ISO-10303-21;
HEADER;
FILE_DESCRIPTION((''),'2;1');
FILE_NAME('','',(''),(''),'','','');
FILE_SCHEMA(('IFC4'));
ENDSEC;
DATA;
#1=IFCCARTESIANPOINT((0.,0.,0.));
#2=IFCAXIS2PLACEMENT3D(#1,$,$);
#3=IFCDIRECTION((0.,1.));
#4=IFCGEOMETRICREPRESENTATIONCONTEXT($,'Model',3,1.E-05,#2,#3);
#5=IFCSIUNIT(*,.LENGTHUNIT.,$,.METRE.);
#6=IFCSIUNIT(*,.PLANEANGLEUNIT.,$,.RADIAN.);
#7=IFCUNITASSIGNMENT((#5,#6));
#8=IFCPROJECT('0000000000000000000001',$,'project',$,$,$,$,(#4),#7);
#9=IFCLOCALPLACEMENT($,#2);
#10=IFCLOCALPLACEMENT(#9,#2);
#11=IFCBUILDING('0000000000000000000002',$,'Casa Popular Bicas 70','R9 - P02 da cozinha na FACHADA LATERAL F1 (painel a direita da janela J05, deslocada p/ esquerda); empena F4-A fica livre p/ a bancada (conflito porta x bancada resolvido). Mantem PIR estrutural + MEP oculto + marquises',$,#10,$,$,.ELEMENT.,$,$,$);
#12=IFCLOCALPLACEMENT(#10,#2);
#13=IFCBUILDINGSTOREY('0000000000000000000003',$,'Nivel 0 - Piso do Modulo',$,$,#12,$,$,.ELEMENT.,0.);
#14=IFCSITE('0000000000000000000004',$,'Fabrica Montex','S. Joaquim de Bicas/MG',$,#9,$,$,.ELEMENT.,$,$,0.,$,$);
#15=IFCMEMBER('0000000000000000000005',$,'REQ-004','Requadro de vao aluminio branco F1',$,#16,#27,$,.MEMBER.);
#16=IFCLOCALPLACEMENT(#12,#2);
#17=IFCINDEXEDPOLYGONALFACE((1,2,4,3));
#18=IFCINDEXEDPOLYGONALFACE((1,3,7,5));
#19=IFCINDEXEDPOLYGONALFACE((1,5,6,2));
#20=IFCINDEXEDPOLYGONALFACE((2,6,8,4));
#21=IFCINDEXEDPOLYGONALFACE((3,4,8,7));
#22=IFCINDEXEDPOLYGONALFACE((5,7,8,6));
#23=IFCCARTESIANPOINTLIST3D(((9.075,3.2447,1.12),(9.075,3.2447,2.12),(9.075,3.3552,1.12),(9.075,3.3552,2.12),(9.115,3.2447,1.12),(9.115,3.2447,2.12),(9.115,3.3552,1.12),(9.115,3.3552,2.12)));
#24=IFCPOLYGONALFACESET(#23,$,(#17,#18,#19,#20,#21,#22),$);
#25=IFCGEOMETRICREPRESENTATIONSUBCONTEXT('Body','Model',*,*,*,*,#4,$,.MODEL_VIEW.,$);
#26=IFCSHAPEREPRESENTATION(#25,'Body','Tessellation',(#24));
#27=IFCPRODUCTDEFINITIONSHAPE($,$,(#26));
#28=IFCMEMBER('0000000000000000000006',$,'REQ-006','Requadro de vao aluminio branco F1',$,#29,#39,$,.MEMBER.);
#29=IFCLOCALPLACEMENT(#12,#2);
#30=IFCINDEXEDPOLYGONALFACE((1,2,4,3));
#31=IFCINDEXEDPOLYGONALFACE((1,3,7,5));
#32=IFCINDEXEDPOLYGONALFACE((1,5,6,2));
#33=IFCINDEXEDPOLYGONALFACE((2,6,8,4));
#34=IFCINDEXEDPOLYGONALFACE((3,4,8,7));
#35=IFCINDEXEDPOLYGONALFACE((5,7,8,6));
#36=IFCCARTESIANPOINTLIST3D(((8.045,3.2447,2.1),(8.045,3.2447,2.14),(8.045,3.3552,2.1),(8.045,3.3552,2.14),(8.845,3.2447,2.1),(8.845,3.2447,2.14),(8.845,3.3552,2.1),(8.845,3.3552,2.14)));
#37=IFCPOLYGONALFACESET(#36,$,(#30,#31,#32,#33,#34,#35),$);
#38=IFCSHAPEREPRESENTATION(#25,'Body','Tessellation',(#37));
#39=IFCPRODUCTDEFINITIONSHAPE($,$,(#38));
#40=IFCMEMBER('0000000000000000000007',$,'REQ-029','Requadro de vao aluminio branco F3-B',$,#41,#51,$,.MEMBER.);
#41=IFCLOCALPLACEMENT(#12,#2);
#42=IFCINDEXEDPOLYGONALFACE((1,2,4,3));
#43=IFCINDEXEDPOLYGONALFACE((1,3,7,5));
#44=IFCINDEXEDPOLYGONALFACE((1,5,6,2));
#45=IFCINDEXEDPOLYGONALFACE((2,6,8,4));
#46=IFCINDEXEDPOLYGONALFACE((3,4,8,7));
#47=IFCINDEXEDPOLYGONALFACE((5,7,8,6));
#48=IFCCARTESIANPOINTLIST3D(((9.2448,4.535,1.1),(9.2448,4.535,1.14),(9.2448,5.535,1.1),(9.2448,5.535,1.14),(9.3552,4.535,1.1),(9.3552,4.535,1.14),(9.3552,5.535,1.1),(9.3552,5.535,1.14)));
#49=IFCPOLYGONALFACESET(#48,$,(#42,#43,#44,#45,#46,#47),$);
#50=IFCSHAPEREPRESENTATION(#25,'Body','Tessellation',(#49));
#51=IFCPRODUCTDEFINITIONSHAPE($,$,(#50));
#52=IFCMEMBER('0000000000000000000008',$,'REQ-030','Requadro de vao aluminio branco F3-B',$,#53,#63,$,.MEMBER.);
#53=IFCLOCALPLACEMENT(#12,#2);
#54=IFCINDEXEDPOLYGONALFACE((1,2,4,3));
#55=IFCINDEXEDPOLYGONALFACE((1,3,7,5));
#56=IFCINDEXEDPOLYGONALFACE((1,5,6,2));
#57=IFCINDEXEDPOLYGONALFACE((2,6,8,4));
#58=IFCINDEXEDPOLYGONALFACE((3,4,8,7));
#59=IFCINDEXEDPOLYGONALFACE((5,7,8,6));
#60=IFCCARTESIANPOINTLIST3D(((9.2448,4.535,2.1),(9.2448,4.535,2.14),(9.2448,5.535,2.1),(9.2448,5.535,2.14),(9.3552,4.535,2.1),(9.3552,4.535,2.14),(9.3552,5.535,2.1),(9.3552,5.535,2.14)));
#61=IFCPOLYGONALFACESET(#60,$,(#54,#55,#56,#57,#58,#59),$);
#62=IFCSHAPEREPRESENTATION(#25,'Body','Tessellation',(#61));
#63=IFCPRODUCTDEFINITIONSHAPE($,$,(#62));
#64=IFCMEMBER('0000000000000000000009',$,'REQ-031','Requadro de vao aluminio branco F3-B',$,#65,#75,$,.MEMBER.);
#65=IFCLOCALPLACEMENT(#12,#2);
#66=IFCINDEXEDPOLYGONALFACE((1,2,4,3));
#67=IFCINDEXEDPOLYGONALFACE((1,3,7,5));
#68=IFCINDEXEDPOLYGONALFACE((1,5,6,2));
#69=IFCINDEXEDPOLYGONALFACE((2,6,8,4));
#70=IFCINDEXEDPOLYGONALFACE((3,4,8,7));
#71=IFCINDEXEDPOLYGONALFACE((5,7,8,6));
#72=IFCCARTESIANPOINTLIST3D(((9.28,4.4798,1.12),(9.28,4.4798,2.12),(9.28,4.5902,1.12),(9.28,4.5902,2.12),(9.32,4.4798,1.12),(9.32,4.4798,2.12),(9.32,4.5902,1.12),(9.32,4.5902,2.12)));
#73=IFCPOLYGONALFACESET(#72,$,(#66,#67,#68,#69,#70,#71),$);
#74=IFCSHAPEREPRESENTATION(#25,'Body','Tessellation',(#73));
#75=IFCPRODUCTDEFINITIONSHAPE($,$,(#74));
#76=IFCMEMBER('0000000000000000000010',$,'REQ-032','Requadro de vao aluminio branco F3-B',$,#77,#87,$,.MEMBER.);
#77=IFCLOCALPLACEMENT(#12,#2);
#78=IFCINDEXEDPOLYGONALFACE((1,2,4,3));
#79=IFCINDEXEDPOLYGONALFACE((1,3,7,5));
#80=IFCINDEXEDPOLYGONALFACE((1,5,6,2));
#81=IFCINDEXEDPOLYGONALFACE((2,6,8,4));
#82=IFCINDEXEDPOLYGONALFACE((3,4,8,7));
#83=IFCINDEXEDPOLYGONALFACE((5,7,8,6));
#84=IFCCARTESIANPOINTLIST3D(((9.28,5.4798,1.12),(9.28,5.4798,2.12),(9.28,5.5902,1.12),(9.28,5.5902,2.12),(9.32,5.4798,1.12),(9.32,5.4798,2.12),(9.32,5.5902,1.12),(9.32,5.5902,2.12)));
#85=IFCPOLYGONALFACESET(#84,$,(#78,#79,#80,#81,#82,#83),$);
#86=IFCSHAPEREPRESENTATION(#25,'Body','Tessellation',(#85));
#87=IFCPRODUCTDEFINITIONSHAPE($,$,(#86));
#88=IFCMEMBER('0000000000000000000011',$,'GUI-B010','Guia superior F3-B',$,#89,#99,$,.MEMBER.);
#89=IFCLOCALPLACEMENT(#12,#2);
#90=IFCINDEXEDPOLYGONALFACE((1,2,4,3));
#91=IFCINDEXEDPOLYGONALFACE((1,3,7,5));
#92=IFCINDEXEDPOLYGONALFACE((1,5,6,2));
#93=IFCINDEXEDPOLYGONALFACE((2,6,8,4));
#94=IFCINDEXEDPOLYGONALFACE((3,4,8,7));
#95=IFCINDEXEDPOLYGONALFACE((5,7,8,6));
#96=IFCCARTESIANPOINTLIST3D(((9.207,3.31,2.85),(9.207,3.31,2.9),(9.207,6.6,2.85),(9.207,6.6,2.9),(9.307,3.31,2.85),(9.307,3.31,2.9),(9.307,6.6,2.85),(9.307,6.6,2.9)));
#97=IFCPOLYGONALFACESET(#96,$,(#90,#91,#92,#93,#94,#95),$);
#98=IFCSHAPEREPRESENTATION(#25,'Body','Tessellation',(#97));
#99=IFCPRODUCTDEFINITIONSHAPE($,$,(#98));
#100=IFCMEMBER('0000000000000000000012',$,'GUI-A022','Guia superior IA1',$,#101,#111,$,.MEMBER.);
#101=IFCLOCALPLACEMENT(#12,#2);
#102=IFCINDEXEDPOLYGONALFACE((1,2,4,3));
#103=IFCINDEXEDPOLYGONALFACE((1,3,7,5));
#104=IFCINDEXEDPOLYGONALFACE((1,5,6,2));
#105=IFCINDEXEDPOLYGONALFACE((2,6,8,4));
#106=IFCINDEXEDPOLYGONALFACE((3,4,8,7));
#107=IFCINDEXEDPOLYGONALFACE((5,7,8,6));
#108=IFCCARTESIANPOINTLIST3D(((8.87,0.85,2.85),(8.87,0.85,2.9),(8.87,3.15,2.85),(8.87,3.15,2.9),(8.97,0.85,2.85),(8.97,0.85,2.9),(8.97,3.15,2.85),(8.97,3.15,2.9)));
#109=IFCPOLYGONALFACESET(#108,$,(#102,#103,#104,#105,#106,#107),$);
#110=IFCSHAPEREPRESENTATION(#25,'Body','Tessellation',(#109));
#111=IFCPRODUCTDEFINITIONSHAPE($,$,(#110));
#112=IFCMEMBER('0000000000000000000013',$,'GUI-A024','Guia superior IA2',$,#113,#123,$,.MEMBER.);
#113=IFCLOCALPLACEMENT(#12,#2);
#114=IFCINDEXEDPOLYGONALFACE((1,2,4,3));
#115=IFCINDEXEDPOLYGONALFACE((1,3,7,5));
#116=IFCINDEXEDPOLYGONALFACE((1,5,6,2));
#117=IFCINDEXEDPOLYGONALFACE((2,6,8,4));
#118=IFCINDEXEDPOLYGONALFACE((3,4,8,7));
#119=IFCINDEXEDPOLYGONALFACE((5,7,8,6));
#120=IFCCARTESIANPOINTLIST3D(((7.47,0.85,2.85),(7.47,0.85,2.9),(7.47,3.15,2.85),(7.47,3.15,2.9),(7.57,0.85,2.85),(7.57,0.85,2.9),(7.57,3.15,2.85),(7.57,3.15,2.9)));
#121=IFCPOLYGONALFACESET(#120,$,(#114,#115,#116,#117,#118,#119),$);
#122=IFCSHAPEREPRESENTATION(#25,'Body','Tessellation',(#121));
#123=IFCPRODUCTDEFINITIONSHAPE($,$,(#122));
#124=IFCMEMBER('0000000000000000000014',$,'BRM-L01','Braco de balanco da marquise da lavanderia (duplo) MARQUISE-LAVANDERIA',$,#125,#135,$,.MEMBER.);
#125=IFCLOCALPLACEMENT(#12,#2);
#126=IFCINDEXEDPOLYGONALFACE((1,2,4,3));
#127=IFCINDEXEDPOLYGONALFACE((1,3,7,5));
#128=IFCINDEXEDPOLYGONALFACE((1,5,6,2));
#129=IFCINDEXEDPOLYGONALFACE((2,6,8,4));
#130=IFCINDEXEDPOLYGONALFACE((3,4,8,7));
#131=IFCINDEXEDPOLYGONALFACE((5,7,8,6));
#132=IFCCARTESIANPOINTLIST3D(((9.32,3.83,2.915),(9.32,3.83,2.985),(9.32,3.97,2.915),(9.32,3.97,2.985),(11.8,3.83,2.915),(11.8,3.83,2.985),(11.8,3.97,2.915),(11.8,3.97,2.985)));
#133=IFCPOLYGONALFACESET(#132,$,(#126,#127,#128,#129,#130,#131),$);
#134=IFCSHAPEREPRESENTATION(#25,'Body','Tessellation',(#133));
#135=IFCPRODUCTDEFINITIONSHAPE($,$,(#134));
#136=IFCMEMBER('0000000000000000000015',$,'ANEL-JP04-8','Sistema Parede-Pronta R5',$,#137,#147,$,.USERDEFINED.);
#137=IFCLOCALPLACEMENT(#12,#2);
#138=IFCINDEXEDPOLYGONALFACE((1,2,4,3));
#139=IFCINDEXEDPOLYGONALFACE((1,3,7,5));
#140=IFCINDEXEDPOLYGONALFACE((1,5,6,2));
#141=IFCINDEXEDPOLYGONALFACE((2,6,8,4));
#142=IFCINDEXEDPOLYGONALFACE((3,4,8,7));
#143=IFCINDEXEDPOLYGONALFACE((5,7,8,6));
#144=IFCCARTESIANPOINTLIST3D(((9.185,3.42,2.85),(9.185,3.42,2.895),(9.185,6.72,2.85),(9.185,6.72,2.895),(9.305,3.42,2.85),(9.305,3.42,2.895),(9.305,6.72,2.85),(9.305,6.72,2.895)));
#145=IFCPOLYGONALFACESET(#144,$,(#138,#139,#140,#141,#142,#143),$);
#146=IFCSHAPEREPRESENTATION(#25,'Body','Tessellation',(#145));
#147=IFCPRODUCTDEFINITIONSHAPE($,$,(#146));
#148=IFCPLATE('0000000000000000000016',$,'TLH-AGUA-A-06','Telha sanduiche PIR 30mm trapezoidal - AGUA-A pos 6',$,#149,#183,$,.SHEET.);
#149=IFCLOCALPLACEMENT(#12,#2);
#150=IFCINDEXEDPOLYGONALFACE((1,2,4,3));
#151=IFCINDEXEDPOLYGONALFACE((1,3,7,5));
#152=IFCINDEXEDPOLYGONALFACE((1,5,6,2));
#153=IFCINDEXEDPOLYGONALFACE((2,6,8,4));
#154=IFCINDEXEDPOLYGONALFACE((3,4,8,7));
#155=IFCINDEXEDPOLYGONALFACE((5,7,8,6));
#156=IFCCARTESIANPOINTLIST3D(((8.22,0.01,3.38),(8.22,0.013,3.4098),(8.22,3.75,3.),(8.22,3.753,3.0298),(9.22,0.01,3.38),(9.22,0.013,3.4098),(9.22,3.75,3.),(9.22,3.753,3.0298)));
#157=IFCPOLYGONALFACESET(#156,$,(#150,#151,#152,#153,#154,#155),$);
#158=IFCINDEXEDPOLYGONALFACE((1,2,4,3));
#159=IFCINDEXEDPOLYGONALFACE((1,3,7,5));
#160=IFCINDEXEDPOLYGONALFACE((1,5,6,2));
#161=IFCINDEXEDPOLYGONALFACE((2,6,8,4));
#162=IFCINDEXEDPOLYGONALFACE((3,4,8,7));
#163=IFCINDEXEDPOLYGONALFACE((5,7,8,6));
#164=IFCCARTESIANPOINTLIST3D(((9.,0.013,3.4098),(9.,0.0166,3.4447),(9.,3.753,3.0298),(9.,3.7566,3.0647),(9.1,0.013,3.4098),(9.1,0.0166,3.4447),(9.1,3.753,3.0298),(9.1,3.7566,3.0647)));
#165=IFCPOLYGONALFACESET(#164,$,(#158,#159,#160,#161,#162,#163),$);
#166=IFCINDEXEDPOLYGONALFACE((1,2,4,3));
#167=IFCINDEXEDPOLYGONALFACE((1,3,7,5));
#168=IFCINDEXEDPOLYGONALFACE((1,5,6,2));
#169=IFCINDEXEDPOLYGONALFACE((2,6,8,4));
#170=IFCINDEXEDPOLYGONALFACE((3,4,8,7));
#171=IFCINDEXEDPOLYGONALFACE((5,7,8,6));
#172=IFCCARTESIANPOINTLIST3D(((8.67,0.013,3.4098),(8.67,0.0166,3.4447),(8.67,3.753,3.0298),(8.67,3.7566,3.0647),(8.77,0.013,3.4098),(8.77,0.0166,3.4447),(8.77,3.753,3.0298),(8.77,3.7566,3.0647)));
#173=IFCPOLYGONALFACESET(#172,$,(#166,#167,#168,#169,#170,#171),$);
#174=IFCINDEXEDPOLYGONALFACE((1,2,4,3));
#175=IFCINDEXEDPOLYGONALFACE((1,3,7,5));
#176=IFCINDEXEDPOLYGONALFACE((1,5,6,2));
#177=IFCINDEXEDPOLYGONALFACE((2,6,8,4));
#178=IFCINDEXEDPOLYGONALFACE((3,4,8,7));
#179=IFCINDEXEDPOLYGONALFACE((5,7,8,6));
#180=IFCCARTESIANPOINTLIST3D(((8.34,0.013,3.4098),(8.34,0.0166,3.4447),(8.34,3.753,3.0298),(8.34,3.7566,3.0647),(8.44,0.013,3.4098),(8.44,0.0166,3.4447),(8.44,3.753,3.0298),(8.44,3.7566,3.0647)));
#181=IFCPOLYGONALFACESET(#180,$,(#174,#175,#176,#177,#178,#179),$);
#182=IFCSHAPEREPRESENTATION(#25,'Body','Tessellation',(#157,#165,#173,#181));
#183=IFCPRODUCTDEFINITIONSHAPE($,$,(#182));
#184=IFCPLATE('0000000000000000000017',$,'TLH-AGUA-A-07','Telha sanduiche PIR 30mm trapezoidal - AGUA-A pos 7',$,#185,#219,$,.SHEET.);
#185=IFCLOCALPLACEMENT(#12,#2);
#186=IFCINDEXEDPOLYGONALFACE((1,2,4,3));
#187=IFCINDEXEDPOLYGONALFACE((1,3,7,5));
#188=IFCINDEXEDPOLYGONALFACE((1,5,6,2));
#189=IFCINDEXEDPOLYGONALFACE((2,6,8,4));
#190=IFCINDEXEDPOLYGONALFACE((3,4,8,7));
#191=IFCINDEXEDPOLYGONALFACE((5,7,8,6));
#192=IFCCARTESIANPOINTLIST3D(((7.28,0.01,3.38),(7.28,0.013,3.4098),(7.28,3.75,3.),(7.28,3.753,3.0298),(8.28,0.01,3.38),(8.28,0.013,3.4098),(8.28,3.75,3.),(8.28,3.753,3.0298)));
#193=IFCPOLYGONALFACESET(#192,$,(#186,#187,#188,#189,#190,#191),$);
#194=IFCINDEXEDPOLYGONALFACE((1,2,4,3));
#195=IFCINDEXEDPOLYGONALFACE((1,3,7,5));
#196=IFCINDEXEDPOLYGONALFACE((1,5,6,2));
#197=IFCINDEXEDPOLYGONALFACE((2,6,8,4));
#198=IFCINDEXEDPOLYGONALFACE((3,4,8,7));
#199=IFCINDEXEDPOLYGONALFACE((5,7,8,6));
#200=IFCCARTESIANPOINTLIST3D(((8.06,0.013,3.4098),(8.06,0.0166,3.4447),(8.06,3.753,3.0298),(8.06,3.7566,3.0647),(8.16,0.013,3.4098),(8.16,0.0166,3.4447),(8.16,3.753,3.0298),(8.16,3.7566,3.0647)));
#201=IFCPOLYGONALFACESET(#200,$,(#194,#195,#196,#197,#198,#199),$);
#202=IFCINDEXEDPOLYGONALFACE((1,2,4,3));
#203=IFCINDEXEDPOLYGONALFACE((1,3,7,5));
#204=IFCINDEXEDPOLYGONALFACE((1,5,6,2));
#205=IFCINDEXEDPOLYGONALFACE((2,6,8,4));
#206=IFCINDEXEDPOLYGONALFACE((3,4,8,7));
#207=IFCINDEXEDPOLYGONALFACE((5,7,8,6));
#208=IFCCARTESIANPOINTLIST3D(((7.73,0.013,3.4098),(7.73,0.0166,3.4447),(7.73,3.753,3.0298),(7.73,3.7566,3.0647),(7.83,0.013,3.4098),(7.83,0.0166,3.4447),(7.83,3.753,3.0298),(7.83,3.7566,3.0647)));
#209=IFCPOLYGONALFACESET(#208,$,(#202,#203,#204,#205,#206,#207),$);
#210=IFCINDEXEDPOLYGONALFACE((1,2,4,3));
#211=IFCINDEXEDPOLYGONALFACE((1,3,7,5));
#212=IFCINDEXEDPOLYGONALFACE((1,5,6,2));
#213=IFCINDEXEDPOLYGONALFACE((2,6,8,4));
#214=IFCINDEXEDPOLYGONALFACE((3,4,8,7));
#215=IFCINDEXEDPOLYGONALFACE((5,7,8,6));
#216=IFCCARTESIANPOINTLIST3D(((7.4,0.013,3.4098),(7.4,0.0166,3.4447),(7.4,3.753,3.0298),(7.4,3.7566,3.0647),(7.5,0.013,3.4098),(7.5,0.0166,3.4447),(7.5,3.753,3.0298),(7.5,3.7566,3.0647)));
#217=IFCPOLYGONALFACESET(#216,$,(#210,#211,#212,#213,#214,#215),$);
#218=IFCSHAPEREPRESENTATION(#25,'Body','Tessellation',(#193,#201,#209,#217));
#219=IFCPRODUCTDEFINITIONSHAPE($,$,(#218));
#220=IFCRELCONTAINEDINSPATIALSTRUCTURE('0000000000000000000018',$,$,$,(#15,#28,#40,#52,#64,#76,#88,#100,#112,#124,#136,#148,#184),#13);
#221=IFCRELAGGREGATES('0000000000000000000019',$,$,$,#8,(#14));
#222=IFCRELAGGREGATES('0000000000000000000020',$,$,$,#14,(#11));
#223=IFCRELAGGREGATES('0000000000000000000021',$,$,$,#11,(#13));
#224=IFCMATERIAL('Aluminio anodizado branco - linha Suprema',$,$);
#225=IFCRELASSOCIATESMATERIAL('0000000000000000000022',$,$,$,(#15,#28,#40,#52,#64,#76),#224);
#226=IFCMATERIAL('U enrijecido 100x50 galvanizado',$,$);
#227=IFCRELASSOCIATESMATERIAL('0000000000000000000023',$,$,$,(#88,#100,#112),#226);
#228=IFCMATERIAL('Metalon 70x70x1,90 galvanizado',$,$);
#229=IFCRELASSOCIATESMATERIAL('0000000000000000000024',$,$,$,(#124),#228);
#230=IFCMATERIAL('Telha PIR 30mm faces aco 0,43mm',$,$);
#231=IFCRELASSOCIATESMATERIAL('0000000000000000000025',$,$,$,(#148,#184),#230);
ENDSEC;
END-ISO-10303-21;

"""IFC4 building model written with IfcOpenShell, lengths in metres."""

from ifc_helpers import new_model, si_unit, direction, frame, frame_2d, origin, origin_2d, place, context, subcontext, project, spatial, rectangle, extrude, material, element, save


model = new_model("IFC4")

# Units and contexts
model_context = context("Model", 3, precision=1e-05, world=origin(), true_north=direction((0.0, 1.0)))
body_context = subcontext(model_context, "Body", "Model", "MODEL_VIEW")
ifc_project = project(units=[si_unit("LENGTHUNIT", "METRE"), si_unit("PLANEANGLEUNIT", "RADIAN")], contexts=[model_context])

# Site, building, storey
site_placement = place(None, origin())
site = spatial("IfcSite", under=ifc_project, at=site_placement, Name="Fabrica Montex", Description="S. Joaquim de Bicas/MG", CompositionType="ELEMENT", RefElevation=0.0)
building_placement = place(site_placement, origin())
building = spatial("IfcBuilding", under=site, at=building_placement, Name="Casa Popular Bicas 70", Description="R9 - P02 da cozinha na FACHADA LATERAL F1 (painel a direita da janela J05, deslocada p/ esquerda); empena F4-A fica livre p/ a bancada (conflito porta x bancada resolvido). Mantem PIR estrutural + MEP oculto + marquises", CompositionType="ELEMENT")
storey_placement = place(building_placement, origin())
storey = spatial("IfcBuildingStorey", under=building, at=storey_placement, Name="Nivel 0 - Piso do Modulo", CompositionType="ELEMENT", Elevation=0.0)

# Members
ifc_material_1 = material(Name="Aluminio anodizado branco - linha Suprema")
member_1_placement = place(None, frame((9.095, 3.3, 1.12), z_axis=(0.0, 0.0, 1.0), x_axis=(-1.0, 0.0, 0.0)))
element("IfcMember", 1, at=member_1_placement, inside=storey, material=ifc_material_1, Name="REQ-004", Description="Requadro de vao aluminio branco F1", PredefinedType="MEMBER", context=body_context, shape_type="SweptSolid", body=[
    extrude(rectangle(XDim=0.04, YDim=0.1105, at=origin_2d()), origin(), (0.0, 0.0, 1.0), 1.0),
])
member_2_placement = place(None, frame((8.845, 3.3, 2.12), z_axis=(-1.0, 0.0, 0.0), x_axis=(0.0, 0.0, 1.0)))
element("IfcMember", 2, at=member_2_placement, inside=storey, material=ifc_material_1, Name="REQ-006", Description="Requadro de vao aluminio branco F1", PredefinedType="MEMBER", context=body_context, shape_type="SweptSolid", body=[
    extrude(rectangle(XDim=0.04, YDim=0.1105, at=origin_2d()), origin(), (0.0, 0.0, 1.0), 0.8),
])
for number, where, z_axis, x_axis, name in (
    (3, (9.3, 4.535, 1.12), (0.0, 1.0, 0.0), (0.0, 0.0, 1.0), "REQ-029"),
    (4, (9.3, 4.535, 2.12), (0.0, 1.0, 0.0), (0.0, 0.0, 1.0), "REQ-030"),
    (5, (9.3, 4.535, 1.12), (0.0, 0.0, 1.0), (1.0, 0.0, 0.0), "REQ-031"),
    (6, (9.3, 5.535, 1.12), (0.0, 0.0, 1.0), (1.0, 0.0, 0.0), "REQ-032"),
):
    element("IfcMember", number, at=place(storey_placement, frame(where, z_axis=z_axis, x_axis=x_axis)), inside=storey, material=ifc_material_1, Name=name, Description="Requadro de vao aluminio branco F3-B", PredefinedType="MEMBER", context=body_context, shape_type="SweptSolid", body=[
        extrude(rectangle(XDim=0.04, YDim=0.1105, at=origin_2d()), origin(), (0.0, 0.0, 1.0), 1.0),
    ])
ifc_material_2 = material(Name="U enrijecido 100x50 galvanizado")
member_3_placement = place(storey_placement, frame((9.257, 3.31, 2.875), z_axis=(0.0, 1.0, 0.0), x_axis=(0.0, 0.0, 1.0)))
element("IfcMember", 7, at=member_3_placement, inside=storey, material=ifc_material_2, Name="GUI-B010", Description="Guia superior F3-B", PredefinedType="MEMBER", context=body_context, shape_type="SweptSolid", body=[
    extrude(rectangle(XDim=0.05, YDim=0.1, at=origin_2d()), origin(), (0.0, 0.0, 1.0), 3.29),
])
for number, where, z_axis, x_axis, name, description in (
    (8, (8.92, 3.15, 2.875), (0.0, -1.0, 0.0), (0.0, 0.0, 1.0), "GUI-A022", "Guia superior IA1"),
    (9, (7.52, 3.15, 2.875), (0.0, -1.0, 0.0), (0.0, 0.0, 1.0), "GUI-A024", "Guia superior IA2"),
):
    element("IfcMember", number, at=place(None, frame(where, z_axis=z_axis, x_axis=x_axis)), inside=storey, material=ifc_material_2, Name=name, Description=description, PredefinedType="MEMBER", context=body_context, shape_type="SweptSolid", body=[
        extrude(rectangle(XDim=0.05, YDim=0.1, at=origin_2d()), origin(), (0.0, 0.0, 1.0), 2.3),
    ])
ifc_material_3 = material(Name="Metalon 70x70x1,90 galvanizado")
member_4_placement = place(storey_placement, frame((9.32, 3.9, 2.95), z_axis=(1.0, 0.0, 0.0), x_axis=(0.0, 0.0, 1.0)))
element("IfcMember", 10, at=member_4_placement, inside=storey, material=ifc_material_3, Name="BRM-L01", Description="Braco de balanco da marquise da lavanderia (duplo) MARQUISE-LAVANDERIA", PredefinedType="MEMBER", context=body_context, shape_type="SweptSolid", body=[
    extrude(rectangle(XDim=0.07, YDim=0.14, at=origin_2d()), origin(), (0.0, 0.0, 1.0), 2.48),
])
member_5_placement = place(storey_placement, frame((9.245, 5.07, 2.85)))
element("IfcMember", 11, at=member_5_placement, inside=storey, Name="ANEL-JP04-8", Description="Sistema Parede-Pronta R5", PredefinedType="USERDEFINED", context=body_context, shape_type="SweptSolid", body=[
    extrude(rectangle(XDim=0.12, YDim=3.3, at=origin_2d()), origin(), (0.0, 0.0, 1.0), 0.045),
])

# Plates
ifc_material_4 = material(Name="Telha PIR 30mm faces aco 0,43mm")
for number, where, z_axis, x_axis, name, description in (
    (12, (9.22, 3.75, 3.0), (0.0, 0.101084, 0.994878), (-1.0, 0.0, 0.0), "TLH-AGUA-A-06", "Telha sanduiche PIR 30mm trapezoidal - AGUA-A pos 6"),
    (13, (8.28, 3.75, 3.0), (0.0, 0.101084, 0.994878), (-1.0, 0.0, 0.0), "TLH-AGUA-A-07", "Telha sanduiche PIR 30mm trapezoidal - AGUA-A pos 7"),
):
    element("IfcPlate", number, at=place(None, frame(where, z_axis=z_axis, x_axis=x_axis)), inside=storey, material=ifc_material_4, Name=name, Description=description, PredefinedType="SHEET", context=body_context, shape_type="SweptSolid", body=[
        extrude(rectangle(XDim=1.0, YDim=3.7593, at=frame_2d((0.5, 1.8796))), origin(), (0.0, 0.0, 1.0), 0.03),
        extrude(rectangle(XDim=0.1, YDim=3.7593, at=frame_2d((0.17, 1.8796))), frame((0.0, 0.0, 0.03)), (0.0, 0.0, 1.0), 0.035),
        extrude(rectangle(XDim=0.1, YDim=3.7593, at=frame_2d((0.5, 1.8796))), frame((0.0, 0.0, 0.03)), (0.0, 0.0, 1.0), 0.035),
        extrude(rectangle(XDim=0.1, YDim=3.7593, at=frame_2d((0.83, 1.8796))), frame((0.0, 0.0, 0.03)), (0.0, 0.0, 1.0), 0.035),
    ])

save(model, "model.ifc")
